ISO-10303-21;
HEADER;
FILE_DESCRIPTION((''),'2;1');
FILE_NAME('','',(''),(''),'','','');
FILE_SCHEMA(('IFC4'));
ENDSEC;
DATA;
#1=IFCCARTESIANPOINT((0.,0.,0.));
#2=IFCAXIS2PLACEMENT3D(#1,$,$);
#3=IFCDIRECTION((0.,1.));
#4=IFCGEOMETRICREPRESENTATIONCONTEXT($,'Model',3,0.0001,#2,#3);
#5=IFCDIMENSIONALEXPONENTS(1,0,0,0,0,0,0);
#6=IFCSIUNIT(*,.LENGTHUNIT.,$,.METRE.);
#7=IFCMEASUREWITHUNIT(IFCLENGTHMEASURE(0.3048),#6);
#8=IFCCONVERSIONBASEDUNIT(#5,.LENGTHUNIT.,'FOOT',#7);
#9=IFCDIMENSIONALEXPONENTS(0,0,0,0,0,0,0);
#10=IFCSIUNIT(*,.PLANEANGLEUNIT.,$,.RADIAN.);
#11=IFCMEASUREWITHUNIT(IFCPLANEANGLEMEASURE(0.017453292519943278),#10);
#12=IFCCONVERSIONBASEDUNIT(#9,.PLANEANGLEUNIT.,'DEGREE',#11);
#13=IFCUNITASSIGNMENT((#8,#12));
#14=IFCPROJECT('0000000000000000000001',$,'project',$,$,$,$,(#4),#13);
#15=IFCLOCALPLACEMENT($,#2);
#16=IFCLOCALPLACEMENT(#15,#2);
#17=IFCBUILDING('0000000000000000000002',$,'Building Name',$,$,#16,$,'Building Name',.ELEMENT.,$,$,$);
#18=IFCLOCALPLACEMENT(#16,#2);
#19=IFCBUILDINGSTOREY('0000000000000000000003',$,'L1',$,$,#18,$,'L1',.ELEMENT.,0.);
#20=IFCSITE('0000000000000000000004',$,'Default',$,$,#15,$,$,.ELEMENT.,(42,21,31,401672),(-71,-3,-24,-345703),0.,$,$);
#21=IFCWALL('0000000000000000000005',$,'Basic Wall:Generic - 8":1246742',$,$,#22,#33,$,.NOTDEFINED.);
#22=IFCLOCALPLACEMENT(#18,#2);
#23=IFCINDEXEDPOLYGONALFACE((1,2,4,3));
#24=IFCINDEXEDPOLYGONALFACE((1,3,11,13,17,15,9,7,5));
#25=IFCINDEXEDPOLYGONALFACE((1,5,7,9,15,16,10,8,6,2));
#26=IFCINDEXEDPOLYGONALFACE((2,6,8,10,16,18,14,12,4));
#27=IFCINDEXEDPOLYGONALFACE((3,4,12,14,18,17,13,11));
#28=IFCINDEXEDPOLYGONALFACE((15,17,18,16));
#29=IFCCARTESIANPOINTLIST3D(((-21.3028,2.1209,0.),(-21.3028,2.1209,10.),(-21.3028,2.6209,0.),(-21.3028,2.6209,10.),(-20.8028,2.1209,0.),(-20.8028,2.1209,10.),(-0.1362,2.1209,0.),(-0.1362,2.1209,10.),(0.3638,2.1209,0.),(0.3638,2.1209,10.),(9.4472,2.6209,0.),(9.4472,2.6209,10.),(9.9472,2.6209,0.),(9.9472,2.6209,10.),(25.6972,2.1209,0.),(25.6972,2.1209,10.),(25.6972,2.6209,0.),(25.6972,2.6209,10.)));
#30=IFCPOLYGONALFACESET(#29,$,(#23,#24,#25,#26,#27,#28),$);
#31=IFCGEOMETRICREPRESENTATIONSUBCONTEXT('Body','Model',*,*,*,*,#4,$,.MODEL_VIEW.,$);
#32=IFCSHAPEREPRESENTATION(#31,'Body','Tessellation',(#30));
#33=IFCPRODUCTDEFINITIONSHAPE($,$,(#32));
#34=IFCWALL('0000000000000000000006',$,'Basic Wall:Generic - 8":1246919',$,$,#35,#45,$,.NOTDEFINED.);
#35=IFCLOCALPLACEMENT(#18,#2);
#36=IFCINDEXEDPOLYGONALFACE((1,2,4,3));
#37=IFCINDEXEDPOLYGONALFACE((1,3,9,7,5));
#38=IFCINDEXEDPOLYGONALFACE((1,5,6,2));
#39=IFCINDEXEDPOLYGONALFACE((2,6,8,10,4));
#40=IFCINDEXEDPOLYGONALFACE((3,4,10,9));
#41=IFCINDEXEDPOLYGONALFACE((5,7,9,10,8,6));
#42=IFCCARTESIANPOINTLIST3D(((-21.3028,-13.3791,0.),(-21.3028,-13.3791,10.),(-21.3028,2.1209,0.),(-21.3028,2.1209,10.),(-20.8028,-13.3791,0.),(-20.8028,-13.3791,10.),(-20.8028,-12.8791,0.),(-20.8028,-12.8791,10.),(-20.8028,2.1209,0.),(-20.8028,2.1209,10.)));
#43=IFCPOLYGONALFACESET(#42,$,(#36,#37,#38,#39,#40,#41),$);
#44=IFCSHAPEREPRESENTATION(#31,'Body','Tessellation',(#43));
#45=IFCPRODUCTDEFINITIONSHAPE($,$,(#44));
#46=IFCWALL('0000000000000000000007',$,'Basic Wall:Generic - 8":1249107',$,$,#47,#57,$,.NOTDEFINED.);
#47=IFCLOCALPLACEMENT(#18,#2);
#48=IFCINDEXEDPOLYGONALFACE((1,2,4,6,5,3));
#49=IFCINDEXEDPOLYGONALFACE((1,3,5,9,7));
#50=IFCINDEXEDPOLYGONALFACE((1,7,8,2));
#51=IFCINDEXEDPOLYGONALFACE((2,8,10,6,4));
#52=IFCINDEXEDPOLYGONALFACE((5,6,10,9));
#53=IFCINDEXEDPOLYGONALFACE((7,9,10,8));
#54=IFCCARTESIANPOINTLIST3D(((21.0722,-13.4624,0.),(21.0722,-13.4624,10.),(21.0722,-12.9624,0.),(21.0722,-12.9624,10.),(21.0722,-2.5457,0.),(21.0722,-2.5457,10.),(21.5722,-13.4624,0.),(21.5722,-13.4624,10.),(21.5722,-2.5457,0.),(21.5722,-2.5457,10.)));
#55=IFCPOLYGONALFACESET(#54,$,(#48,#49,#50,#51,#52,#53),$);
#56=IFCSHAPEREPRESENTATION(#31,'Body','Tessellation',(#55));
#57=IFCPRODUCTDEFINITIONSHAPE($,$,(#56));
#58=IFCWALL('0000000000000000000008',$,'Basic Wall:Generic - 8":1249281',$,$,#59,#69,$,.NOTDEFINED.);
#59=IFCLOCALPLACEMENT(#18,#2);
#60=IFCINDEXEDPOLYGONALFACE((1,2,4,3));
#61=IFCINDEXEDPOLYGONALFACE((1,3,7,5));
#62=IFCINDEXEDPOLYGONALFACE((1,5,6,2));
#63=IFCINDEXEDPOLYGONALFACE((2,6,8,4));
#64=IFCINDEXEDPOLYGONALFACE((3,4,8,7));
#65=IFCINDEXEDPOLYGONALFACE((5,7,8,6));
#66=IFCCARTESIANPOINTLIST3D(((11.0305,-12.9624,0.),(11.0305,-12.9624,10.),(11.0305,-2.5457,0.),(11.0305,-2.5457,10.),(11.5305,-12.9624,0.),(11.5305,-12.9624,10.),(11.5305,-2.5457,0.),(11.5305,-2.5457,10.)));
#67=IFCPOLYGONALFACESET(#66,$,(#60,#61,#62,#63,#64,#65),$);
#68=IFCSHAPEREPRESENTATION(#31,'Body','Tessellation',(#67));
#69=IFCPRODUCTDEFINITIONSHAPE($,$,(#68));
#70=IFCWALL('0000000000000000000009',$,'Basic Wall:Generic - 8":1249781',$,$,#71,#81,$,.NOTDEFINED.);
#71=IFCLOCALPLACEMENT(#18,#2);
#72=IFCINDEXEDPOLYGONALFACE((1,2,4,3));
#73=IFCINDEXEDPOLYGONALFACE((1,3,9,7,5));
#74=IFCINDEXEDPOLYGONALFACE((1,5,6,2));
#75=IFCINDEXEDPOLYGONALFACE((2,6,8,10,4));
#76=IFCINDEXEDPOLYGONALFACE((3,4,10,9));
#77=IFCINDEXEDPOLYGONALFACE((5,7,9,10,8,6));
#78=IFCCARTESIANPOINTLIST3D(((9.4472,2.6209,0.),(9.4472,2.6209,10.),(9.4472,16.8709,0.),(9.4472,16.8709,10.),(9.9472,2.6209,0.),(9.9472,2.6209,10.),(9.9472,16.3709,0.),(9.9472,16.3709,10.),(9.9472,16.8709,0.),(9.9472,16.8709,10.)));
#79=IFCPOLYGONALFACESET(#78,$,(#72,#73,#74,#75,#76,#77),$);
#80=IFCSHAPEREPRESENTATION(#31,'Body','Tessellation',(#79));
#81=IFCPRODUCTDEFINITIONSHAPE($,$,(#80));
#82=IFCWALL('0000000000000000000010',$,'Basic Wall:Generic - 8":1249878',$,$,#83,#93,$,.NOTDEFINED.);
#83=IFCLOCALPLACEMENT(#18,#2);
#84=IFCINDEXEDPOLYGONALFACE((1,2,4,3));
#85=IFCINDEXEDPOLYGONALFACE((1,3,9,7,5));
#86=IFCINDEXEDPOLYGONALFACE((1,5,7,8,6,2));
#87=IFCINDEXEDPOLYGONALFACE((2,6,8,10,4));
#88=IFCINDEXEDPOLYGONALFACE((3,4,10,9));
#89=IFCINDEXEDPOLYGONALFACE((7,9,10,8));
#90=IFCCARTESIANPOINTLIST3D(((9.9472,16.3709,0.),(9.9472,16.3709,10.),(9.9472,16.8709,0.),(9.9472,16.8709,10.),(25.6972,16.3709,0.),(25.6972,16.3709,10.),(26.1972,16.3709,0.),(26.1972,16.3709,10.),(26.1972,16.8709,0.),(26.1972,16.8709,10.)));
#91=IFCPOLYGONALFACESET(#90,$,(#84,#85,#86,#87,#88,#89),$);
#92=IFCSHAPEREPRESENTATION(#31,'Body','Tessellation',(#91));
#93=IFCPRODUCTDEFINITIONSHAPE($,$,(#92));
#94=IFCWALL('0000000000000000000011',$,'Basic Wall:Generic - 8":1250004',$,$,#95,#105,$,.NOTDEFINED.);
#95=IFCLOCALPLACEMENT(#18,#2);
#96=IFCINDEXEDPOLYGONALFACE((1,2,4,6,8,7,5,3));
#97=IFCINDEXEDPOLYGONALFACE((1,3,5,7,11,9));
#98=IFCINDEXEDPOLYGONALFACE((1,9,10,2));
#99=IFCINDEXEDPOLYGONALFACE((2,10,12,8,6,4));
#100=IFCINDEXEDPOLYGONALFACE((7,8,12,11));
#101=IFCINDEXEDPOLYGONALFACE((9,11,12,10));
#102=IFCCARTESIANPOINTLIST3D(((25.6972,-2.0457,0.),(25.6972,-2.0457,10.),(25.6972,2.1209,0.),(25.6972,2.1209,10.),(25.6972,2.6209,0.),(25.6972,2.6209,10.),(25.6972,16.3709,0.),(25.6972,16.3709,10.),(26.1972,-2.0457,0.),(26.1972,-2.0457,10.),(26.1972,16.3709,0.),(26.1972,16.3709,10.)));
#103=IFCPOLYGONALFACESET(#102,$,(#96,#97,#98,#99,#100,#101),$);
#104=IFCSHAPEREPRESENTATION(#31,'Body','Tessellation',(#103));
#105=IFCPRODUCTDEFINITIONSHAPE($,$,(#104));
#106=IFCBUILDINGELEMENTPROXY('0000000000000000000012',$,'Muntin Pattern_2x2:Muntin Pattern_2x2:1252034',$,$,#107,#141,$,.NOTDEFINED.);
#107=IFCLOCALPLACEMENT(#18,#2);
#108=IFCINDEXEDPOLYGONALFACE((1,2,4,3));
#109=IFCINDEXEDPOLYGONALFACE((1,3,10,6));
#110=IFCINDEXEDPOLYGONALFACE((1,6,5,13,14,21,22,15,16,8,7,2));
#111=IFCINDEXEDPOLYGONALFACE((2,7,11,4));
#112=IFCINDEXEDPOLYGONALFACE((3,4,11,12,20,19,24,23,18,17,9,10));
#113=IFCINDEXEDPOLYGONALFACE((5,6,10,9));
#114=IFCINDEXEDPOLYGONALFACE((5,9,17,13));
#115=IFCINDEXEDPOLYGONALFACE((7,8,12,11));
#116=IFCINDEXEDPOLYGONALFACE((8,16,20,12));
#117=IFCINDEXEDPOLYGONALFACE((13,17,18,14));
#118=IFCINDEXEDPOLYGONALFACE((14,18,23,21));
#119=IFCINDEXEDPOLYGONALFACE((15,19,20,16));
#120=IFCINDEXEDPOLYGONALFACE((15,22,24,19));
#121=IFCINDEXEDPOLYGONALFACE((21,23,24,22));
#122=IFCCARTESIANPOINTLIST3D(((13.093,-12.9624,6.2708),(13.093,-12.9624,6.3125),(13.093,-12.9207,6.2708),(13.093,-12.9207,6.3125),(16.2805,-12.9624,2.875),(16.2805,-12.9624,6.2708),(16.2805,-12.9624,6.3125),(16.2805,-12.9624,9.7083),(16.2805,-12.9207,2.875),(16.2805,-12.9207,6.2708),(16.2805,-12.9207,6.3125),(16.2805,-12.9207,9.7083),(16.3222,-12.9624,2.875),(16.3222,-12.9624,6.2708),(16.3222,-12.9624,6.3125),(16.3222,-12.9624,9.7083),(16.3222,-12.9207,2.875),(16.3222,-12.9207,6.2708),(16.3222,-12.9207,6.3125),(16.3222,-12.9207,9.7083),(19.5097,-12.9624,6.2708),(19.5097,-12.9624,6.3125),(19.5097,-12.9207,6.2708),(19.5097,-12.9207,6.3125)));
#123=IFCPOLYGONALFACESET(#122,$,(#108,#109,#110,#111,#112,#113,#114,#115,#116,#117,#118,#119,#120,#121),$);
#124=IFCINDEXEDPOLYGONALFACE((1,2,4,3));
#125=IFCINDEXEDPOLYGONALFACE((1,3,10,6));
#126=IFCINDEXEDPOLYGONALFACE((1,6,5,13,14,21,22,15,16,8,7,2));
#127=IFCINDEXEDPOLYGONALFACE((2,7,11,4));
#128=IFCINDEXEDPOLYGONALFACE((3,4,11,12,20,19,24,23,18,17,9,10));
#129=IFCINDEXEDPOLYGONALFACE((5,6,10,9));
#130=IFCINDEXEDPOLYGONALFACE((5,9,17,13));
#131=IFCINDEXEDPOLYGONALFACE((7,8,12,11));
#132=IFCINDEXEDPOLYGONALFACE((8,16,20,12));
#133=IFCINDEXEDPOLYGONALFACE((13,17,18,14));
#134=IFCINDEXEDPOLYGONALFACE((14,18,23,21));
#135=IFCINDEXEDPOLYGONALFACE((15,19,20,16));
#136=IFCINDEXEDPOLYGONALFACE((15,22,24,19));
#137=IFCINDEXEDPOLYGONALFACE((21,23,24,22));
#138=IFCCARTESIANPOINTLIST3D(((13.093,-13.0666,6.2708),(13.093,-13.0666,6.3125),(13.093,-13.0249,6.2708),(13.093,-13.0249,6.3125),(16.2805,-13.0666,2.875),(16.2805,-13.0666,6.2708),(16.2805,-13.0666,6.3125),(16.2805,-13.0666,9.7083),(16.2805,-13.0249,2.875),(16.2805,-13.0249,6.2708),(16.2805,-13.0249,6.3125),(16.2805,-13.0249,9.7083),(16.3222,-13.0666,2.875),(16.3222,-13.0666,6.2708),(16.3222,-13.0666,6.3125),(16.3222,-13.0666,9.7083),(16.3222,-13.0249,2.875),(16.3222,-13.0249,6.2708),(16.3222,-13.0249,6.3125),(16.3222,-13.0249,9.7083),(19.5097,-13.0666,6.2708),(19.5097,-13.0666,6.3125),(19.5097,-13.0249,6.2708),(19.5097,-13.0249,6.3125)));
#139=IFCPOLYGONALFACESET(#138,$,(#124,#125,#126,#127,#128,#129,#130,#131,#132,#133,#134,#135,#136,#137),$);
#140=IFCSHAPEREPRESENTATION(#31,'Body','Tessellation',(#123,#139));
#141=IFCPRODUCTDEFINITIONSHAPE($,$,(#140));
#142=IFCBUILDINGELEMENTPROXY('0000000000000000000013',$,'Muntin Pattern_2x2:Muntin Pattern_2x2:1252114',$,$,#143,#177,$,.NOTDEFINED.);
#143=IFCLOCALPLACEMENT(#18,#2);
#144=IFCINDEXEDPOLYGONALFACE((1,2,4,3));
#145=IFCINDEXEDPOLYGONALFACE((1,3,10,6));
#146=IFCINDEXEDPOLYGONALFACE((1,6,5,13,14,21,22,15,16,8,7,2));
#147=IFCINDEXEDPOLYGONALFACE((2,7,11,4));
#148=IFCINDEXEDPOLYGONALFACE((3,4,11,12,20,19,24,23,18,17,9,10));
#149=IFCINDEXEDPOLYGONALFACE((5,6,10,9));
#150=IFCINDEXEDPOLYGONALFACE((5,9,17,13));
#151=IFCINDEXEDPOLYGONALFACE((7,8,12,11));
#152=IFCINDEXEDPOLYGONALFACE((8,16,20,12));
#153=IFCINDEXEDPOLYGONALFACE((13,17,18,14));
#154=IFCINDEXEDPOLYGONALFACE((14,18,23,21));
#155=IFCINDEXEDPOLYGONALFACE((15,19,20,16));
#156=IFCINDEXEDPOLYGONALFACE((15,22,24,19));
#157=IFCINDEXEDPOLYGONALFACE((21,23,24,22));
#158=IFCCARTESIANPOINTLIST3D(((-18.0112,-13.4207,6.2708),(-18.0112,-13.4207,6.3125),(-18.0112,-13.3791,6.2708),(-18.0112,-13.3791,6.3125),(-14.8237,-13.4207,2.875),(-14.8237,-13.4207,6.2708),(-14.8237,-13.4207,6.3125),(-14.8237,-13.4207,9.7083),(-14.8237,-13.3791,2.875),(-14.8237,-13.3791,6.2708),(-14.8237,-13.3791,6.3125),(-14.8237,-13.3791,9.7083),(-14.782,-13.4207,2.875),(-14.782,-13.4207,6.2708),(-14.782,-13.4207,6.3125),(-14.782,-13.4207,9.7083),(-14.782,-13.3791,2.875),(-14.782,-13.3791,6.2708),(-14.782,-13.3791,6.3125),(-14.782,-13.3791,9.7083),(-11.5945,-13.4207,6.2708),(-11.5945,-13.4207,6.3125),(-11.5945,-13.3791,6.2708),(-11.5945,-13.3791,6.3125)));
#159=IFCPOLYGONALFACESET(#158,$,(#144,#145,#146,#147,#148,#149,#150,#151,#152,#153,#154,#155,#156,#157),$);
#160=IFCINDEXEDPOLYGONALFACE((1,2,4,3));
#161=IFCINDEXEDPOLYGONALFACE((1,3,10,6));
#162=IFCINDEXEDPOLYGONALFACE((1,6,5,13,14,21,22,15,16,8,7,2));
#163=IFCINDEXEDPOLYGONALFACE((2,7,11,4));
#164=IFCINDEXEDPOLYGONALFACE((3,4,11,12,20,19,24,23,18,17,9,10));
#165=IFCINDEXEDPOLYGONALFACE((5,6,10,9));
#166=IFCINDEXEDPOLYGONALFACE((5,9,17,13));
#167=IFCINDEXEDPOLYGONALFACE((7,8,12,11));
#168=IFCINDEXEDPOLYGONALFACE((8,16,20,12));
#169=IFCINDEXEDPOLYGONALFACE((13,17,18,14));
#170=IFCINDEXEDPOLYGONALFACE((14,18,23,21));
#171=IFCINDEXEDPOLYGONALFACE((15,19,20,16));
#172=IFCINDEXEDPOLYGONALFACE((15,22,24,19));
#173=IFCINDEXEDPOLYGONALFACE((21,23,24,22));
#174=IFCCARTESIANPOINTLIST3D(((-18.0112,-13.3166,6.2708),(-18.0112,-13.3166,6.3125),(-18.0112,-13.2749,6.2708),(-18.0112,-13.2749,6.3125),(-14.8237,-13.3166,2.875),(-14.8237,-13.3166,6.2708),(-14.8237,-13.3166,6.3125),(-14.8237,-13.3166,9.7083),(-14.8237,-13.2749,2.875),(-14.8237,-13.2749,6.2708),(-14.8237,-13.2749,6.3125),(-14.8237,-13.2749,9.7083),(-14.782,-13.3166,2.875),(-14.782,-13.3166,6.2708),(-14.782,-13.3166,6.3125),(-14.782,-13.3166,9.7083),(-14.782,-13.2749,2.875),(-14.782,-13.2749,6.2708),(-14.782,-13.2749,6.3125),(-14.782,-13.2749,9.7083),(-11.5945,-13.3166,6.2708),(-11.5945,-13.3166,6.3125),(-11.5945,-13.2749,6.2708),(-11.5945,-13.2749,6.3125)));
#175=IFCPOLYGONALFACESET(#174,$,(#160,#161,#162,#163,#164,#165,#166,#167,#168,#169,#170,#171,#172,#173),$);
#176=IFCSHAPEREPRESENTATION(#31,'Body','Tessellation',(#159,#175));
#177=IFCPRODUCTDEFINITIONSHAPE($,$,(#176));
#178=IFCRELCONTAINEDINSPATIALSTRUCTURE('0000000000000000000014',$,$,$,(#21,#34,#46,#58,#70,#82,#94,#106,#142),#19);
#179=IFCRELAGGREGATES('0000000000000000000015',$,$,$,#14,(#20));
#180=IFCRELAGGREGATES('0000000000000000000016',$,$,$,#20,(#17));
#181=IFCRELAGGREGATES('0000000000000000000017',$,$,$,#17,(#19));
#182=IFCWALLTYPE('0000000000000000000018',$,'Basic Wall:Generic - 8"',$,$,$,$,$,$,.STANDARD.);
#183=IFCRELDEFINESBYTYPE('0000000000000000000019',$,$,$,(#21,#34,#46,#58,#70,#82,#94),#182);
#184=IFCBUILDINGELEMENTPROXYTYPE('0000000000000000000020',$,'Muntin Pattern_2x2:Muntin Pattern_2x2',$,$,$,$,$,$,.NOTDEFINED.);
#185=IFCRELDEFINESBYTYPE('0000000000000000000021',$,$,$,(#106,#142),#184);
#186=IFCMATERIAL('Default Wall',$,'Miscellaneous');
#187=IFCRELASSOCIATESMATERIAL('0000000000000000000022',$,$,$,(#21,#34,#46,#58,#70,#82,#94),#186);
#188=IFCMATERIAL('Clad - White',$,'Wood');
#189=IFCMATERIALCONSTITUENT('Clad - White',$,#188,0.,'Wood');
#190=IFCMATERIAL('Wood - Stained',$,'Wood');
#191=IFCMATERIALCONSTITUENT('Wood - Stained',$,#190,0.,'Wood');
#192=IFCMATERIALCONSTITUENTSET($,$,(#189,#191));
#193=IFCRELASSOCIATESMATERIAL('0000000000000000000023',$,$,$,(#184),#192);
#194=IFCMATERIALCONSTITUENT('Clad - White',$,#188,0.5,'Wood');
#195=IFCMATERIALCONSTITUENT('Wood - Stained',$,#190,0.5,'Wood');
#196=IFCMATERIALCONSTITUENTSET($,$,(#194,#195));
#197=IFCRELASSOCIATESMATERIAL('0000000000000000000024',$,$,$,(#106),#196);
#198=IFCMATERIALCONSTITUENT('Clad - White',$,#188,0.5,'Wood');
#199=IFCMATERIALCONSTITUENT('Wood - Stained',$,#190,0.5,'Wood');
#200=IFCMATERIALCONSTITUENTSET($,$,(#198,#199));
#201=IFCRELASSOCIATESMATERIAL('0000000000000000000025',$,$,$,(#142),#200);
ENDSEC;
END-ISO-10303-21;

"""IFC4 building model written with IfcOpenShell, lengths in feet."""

from ifc_helpers import new_model, entity, si_unit, converted_unit, direction, frame, origin, place, context, subcontext, project, spatial, indexed_curve, outline, extrude, source, transform, mapped, material, constituent, constituent_set, type_object, type_shapes, element, save


model = new_model("IFC4")

# Units and contexts
model_context = context("Model", 3, precision=0.0001, world=origin(), true_north=direction((0.0, 1.0)))
body_context = subcontext(model_context, "Body", "Model", "MODEL_VIEW")
ifc_project = project(units=[converted_unit("LENGTHUNIT", "FOOT", entity("IfcLengthMeasure", 0.3048), si_unit("LENGTHUNIT", "METRE"), dimensions=[1, 0, 0, 0, 0, 0, 0]), converted_unit("PLANEANGLEUNIT", "DEGREE", entity("IfcPlaneAngleMeasure", 0.017453292519943278), si_unit("PLANEANGLEUNIT", "RADIAN"), dimensions=[0, 0, 0, 0, 0, 0, 0])], contexts=[model_context])

# Site, building, storey
site_placement = place(None, origin())
site = spatial("IfcSite", under=ifc_project, at=site_placement, Name="Default", CompositionType="ELEMENT", RefLatitude=(42, 21, 31, 401672), RefLongitude=(-71, -3, -24, -345703), RefElevation=0.0)
building_placement = place(site_placement, origin())
building = spatial("IfcBuilding", under=site, at=building_placement, Name="Building Name", LongName="Building Name", CompositionType="ELEMENT")
storey_placement = place(building_placement, origin())
storey = spatial("IfcBuildingStorey", under=building, at=storey_placement, Name="L1", LongName="L1", CompositionType="ELEMENT", Elevation=0.0)

# Walls
ifc_material_1 = material(Name="Default Wall", Category="Miscellaneous")
wall_type = type_object("IfcWallType", Name="Basic Wall:Generic - 8\"", PredefinedType="STANDARD")
wall_1_placement = place(storey_placement, frame((-21.3028, 2.3709, 0.0)))
element("IfcWall", 1, at=wall_1_placement, inside=storey, type_object=wall_type, material=ifc_material_1, Name="Basic Wall:Generic - 8\":1246742", PredefinedType="NOTDEFINED", context=body_context, shape_type="SweptSolid", body=[
    extrude(outline(indexed_curve([(47.0, -0.25), (47.0, 0.25), (31.25, 0.25), (30.75, 0.25), (0.0, 0.25), (0.0, -0.25), (0.5, -0.25), (21.1667, -0.25), (21.6667, -0.25), (47.0, -0.25)], self_intersect=False)), origin(), (0.0, 0.0, 1.0), 10.0),
])
wall_2_placement = place(storey_placement, frame((-21.0528, -13.3791, 0.0), z_axis=(0.0, 0.0, 1.0), x_axis=(0.0, 1.0, 0.0)))
element("IfcWall", 2, at=wall_2_placement, inside=storey, type_object=wall_type, material=ifc_material_1, Name="Basic Wall:Generic - 8\":1246919", PredefinedType="NOTDEFINED", context=body_context, shape_type="SweptSolid", body=[
    extrude(outline(indexed_curve([(15.5, -0.25), (15.5, 0.25), (0.0, 0.25), (0.0, -0.25), (0.5, -0.25), (15.5, -0.25)], self_intersect=False)), origin(), (0.0, 0.0, 1.0), 10.0),
])
wall_3_placement = place(storey_placement, frame((21.3222, -2.5457, 0.0), z_axis=(0.0, 0.0, 1.0), x_axis=(0.0, -1.0, 0.0)))
element("IfcWall", 3, at=wall_3_placement, inside=storey, type_object=wall_type, material=ifc_material_1, Name="Basic Wall:Generic - 8\":1249107", PredefinedType="NOTDEFINED", context=body_context, shape_type="SweptSolid", body=[
    extrude(outline(indexed_curve([(10.9167, -0.25), (10.9167, 0.25), (0.0, 0.25), (0.0, -0.25), (10.4167, -0.25), (10.9167, -0.25)], self_intersect=False)), origin(), (0.0, 0.0, 1.0), 10.0),
])
wall_4_placement = place(storey_placement, frame((11.2805, -12.9624, 0.0), z_axis=(0.0, 0.0, 1.0), x_axis=(0.0, 1.0, 0.0)))
element("IfcWall", 4, at=wall_4_placement, inside=storey, type_object=wall_type, material=ifc_material_1, Name="Basic Wall:Generic - 8\":1249281", PredefinedType="NOTDEFINED", context=body_context, shape_type="SweptSolid", body=[
    extrude(outline(indexed_curve([(10.4167, -0.25), (10.4167, 0.25), (0.0, 0.25), (0.0, -0.25), (10.4167, -0.25)], self_intersect=False)), origin(), (0.0, 0.0, 1.0), 10.0),
])
wall_5_placement = place(storey_placement, frame((9.6972, 2.6209, 0.0), z_axis=(0.0, 0.0, 1.0), x_axis=(0.0, 1.0, 0.0)))
element("IfcWall", 5, at=wall_5_placement, inside=storey, type_object=wall_type, material=ifc_material_1, Name="Basic Wall:Generic - 8\":1249781", PredefinedType="NOTDEFINED", context=body_context, shape_type="SweptSolid", body=[
    extrude(outline(indexed_curve([(14.25, -0.25), (14.25, 0.25), (0.0, 0.25), (0.0, -0.25), (13.75, -0.25), (14.25, -0.25)], self_intersect=False)), origin(), (0.0, 0.0, 1.0), 10.0),
])
wall_6_placement = place(storey_placement, frame((9.9472, 16.6209, 0.0)))
element("IfcWall", 6, at=wall_6_placement, inside=storey, type_object=wall_type, material=ifc_material_1, Name="Basic Wall:Generic - 8\":1249878", PredefinedType="NOTDEFINED", context=body_context, shape_type="SweptSolid", body=[
    extrude(outline(indexed_curve([(16.25, -0.25), (16.25, 0.25), (0.0, 0.25), (0.0, -0.25), (15.75, -0.25), (16.25, -0.25)], self_intersect=False)), origin(), (0.0, 0.0, 1.0), 10.0),
])
wall_7_placement = place(storey_placement, frame((25.9472, 16.3709, 0.0), z_axis=(0.0, 0.0, 1.0), x_axis=(0.0, -1.0, 0.0)))
element("IfcWall", 7, at=wall_7_placement, inside=storey, type_object=wall_type, material=ifc_material_1, Name="Basic Wall:Generic - 8\":1250004", PredefinedType="NOTDEFINED", context=body_context, shape_type="SweptSolid", body=[
    extrude(outline(indexed_curve([(18.4167, -0.25), (18.4167, 0.25), (0.0, 0.25), (0.0, -0.25), (13.75, -0.25), (14.25, -0.25), (18.4167, -0.25)], self_intersect=False)), origin(), (0.0, 0.0, 1.0), 10.0),
])

# Building element proxies
ifc_material_2 = material(Name="Clad - White", Category="Wood")
ifc_constituent_1 = constituent(ifc_material_2, Name="Clad - White", Category="Wood", fraction=0.5)
ifc_material_3 = material(Name="Wood - Stained", Category="Wood")
ifc_constituent_2 = constituent(ifc_material_3, Name="Wood - Stained", Category="Wood", fraction=0.5)
ifc_constituent_set_1 = constituent_set(constituents=[ifc_constituent_1, ifc_constituent_2])
ifc_constituent_3 = constituent(ifc_material_2, Name="Clad - White", Category="Wood", fraction=0.0)
ifc_constituent_4 = constituent(ifc_material_3, Name="Wood - Stained", Category="Wood", fraction=0.0)
ifc_constituent_set_2 = constituent_set(constituents=[ifc_constituent_3, ifc_constituent_4])
building_element_proxy_type_1 = type_object("IfcBuildingElementProxyType", Name="Muntin Pattern_2x2:Muntin Pattern_2x2", PredefinedType="NOTDEFINED", material=ifc_constituent_set_2)
shared_shape_1 = source(origin(), body_context, "Body", "SweptSolid", [
    extrude(outline(indexed_curve([(0.0208, -0.0208), (3.4167, -0.0208), (3.4167, 0.0208), (0.0208, 0.0208), (0.0208, 3.2083), (-0.0208, 3.2083), (-0.0208, 0.0208), (-3.4167, 0.0208), (-3.4167, -0.0208), (-0.0208, -0.0208), (-0.0208, -3.2083), (0.0208, -3.2083), (0.0208, -0.0208)], self_intersect=False)), frame((0.0, -0.0729, 3.4167), z_axis=(0.0, 1.0, 0.0), x_axis=(0.0, 0.0, 1.0)), (0.0, 0.0, 1.0), 0.0417),
    extrude(outline(indexed_curve([(0.0208, -0.0208), (3.4167, -0.0208), (3.4167, 0.0208), (0.0208, 0.0208), (0.0208, 3.2083), (-0.0208, 3.2083), (-0.0208, 0.0208), (-3.4167, 0.0208), (-3.4167, -0.0208), (-0.0208, -0.0208), (-0.0208, -3.2083), (0.0208, -3.2083), (0.0208, -0.0208)], self_intersect=False)), frame((0.0, 0.0313, 3.4167), z_axis=(0.0, 1.0, 0.0), x_axis=(0.0, 0.0, 1.0)), (0.0, 0.0, 1.0), 0.0417),
])
type_shapes(building_element_proxy_type_1, [shared_shape_1])
proxy_1_placement = place(storey_placement, frame((16.3013, -12.9936, 2.875), z_axis=(0.0, 0.0, 1.0), x_axis=(-1.0, 0.0, 0.0)))
element("IfcBuildingElementProxy", 8, at=proxy_1_placement, inside=storey, type_object=building_element_proxy_type_1, material=ifc_constituent_set_1, Name="Muntin Pattern_2x2:Muntin Pattern_2x2:1252034", PredefinedType="NOTDEFINED", context=body_context, shape_type="MappedRepresentation", body=[
    mapped(shared_shape_1, transform((0.0, 0.0, 0.0), scale=1.0)),
])
ifc_constituent_5 = constituent(ifc_material_2, Name="Clad - White", Category="Wood", fraction=0.5)
ifc_constituent_6 = constituent(ifc_material_3, Name="Wood - Stained", Category="Wood", fraction=0.5)
ifc_constituent_set_3 = constituent_set(constituents=[ifc_constituent_5, ifc_constituent_6])
proxy_2_placement = place(storey_placement, frame((-14.8028, -13.3478, 2.875)))
element("IfcBuildingElementProxy", 9, at=proxy_2_placement, inside=storey, type_object=building_element_proxy_type_1, material=ifc_constituent_set_3, Name="Muntin Pattern_2x2:Muntin Pattern_2x2:1252114", PredefinedType="NOTDEFINED", context=body_context, shape_type="MappedRepresentation", body=[
    mapped(shared_shape_1, transform((0.0, 0.0, 0.0), scale=1.0)),
])

save(model, "model.ifc")
